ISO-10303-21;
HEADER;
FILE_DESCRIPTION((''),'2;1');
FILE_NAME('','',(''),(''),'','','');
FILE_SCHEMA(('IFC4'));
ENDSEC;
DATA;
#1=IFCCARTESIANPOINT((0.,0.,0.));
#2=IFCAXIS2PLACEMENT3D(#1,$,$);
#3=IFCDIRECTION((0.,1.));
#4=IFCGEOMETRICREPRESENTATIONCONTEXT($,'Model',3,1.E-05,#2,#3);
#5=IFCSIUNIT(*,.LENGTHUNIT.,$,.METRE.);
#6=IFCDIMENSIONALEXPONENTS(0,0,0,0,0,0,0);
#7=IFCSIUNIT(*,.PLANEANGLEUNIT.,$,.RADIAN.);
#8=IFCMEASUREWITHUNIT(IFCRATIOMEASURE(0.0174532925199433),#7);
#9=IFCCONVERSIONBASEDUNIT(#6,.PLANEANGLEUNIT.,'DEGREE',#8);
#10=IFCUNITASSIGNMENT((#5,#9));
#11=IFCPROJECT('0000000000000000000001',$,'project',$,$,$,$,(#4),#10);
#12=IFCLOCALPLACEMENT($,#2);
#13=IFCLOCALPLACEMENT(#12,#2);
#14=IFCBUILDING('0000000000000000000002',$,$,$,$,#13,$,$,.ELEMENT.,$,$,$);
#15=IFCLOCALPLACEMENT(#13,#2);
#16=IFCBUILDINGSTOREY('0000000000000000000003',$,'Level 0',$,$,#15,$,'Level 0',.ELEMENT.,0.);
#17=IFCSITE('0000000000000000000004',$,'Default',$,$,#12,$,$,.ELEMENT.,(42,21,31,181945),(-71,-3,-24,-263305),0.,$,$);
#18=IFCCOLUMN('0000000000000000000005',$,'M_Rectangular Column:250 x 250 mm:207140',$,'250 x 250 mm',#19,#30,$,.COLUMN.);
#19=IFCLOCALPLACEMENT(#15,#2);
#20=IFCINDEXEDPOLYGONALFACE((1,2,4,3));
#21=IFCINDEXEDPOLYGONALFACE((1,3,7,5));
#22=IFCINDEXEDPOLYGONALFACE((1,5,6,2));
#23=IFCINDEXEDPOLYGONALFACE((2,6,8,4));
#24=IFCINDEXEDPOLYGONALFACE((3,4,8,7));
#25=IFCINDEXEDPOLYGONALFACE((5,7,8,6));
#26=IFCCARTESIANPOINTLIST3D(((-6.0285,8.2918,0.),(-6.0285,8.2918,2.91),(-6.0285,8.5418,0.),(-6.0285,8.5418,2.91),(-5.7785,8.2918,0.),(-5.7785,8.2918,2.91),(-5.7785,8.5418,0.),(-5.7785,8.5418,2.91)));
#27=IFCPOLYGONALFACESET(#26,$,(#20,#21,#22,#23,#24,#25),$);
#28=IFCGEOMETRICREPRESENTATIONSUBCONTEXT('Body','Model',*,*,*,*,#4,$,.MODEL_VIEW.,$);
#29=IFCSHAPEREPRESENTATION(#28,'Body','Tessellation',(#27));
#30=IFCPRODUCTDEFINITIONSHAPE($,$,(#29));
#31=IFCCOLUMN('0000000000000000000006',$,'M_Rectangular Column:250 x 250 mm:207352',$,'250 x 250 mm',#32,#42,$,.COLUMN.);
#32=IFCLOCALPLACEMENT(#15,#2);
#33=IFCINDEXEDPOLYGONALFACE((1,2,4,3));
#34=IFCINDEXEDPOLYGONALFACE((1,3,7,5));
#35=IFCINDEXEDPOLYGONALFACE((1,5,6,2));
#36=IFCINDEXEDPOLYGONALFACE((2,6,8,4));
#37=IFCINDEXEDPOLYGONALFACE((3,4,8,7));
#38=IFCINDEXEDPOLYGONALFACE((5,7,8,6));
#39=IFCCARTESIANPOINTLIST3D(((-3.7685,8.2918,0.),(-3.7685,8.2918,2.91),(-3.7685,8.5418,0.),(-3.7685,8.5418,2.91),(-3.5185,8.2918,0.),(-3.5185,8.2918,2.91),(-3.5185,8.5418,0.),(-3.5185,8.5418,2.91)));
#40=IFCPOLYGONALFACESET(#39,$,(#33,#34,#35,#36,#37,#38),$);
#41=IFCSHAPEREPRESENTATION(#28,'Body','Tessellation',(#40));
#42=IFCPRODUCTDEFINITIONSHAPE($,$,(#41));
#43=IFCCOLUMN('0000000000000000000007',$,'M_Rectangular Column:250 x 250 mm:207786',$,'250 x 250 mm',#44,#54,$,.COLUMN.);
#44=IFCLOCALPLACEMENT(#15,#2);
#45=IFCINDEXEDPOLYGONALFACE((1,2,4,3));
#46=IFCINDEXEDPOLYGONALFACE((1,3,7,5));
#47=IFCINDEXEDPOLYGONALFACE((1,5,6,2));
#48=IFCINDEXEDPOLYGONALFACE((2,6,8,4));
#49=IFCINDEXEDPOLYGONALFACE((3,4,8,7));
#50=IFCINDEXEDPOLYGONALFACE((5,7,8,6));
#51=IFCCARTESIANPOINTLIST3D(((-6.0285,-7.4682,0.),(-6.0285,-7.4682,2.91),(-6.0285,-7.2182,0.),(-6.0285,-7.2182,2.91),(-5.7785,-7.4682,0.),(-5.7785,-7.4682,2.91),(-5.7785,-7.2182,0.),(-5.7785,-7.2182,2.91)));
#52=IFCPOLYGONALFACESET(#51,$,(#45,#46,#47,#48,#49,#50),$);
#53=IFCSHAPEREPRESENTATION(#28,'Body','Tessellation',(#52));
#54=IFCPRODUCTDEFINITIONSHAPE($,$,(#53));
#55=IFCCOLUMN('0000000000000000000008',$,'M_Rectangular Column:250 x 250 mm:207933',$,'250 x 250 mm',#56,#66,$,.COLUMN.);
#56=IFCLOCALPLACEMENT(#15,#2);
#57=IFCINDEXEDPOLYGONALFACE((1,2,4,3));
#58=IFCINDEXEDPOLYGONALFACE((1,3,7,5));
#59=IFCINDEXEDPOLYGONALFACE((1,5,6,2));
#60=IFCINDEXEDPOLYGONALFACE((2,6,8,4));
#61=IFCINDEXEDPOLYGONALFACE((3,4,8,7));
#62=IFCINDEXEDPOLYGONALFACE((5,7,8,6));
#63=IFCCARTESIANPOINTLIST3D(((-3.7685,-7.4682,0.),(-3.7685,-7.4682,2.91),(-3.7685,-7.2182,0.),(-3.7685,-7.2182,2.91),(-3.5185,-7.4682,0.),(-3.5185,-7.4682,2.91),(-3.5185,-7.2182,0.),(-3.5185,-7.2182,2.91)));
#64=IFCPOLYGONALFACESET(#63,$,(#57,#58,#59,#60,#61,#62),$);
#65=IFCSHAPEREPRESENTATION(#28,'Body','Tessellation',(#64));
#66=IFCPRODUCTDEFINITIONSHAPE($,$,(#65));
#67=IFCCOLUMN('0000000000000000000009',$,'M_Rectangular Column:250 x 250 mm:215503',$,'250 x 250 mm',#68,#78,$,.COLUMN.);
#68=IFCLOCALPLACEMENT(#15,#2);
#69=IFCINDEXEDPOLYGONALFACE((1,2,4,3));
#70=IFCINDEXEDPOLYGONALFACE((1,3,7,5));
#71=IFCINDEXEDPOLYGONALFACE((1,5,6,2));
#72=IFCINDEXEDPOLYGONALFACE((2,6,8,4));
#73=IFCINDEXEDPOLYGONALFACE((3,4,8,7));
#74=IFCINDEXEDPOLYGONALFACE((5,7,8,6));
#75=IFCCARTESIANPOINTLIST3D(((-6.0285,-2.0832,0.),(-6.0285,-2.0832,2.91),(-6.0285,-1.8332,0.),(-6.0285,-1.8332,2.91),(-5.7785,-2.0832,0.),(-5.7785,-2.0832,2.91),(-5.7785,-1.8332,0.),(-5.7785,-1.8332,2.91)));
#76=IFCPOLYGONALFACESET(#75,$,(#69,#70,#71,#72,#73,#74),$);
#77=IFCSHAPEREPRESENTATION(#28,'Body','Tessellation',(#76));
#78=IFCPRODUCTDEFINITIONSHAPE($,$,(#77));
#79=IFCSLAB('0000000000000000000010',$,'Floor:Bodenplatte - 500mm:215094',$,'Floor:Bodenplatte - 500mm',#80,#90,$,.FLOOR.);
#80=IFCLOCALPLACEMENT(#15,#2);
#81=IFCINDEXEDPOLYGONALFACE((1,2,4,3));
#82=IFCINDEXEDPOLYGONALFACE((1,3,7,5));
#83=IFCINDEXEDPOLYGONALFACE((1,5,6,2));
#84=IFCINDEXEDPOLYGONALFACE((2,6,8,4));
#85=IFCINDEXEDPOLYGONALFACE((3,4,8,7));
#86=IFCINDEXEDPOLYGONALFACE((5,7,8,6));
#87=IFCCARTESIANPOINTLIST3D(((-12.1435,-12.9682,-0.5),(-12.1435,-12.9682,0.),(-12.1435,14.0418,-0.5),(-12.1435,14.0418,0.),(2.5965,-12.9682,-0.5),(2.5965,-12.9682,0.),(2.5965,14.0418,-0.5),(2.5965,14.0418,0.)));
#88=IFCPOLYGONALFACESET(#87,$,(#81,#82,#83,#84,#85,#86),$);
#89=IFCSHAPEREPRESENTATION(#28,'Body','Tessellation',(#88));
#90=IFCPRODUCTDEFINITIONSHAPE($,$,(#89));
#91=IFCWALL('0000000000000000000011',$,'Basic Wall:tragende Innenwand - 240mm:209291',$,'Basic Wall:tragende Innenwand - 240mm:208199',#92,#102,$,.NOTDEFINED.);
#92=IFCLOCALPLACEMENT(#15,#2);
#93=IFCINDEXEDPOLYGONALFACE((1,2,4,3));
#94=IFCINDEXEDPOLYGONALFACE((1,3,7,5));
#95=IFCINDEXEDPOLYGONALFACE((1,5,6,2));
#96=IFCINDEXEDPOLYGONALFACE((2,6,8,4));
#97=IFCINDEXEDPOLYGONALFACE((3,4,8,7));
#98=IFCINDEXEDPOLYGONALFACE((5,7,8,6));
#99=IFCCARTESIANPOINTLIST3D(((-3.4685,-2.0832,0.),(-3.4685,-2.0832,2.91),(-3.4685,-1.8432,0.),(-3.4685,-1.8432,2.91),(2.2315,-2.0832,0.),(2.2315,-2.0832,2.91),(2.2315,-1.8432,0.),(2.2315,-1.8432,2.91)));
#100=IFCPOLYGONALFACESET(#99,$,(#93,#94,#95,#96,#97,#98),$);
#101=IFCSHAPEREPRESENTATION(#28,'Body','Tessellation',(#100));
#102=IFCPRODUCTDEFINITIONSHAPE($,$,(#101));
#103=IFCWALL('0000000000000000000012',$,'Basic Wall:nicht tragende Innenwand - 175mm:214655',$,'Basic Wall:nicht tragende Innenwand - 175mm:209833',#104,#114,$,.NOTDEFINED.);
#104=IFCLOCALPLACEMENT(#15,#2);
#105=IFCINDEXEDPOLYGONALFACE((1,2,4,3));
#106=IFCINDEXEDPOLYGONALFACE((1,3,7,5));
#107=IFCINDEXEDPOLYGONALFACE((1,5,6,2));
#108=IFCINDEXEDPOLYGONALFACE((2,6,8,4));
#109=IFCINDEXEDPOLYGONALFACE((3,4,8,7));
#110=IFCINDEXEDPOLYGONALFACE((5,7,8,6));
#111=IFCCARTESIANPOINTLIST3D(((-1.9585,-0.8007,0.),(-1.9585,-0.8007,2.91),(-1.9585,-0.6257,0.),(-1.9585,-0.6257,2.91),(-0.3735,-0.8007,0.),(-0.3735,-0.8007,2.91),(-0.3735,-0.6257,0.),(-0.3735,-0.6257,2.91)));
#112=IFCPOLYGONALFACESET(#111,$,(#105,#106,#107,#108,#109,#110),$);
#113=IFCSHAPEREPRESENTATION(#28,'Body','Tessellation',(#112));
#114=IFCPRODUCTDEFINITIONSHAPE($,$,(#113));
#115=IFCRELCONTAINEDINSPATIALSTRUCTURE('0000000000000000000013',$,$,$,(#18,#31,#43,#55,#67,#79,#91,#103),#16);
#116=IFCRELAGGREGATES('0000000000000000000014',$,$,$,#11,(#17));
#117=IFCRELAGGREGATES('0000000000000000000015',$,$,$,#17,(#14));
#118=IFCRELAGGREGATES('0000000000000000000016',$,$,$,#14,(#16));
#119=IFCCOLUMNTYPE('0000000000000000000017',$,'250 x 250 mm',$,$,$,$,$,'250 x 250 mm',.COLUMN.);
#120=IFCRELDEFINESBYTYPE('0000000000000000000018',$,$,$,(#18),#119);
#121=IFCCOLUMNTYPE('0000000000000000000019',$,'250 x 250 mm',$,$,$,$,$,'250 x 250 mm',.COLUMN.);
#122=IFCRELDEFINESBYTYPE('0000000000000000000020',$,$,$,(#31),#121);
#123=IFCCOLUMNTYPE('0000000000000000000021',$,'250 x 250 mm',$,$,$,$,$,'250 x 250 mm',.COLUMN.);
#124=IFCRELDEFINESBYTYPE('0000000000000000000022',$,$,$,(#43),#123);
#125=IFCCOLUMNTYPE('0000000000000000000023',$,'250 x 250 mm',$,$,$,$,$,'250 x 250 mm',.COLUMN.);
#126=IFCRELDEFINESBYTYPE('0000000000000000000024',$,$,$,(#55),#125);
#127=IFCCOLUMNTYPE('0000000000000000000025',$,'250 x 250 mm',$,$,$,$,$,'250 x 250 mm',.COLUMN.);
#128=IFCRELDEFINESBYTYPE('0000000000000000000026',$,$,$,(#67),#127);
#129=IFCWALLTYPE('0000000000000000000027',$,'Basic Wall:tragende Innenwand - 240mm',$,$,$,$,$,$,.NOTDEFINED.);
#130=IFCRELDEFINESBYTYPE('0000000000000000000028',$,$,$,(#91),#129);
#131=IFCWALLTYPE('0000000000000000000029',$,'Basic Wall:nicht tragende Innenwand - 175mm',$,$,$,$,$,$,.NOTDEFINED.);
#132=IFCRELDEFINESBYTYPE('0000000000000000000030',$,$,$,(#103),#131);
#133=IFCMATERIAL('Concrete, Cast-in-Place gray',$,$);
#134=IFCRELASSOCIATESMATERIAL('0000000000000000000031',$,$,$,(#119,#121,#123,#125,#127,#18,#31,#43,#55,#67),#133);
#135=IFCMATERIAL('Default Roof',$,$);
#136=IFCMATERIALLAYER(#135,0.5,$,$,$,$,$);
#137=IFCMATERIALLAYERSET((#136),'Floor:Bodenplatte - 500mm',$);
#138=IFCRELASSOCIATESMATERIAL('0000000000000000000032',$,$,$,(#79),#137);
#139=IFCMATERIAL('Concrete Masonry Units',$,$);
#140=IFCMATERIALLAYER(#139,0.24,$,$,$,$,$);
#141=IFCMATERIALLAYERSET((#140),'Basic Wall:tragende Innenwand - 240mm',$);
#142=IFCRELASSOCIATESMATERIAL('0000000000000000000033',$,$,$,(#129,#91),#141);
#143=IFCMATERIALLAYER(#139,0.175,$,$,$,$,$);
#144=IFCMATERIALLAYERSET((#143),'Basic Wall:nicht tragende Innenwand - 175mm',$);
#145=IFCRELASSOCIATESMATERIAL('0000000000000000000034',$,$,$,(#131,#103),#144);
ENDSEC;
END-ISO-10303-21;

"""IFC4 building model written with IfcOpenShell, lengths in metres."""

from ifc_helpers import new_model, entity, si_unit, converted_unit, direction, frame, frame_2d, origin, origin_2d_with_axis, place, context, subcontext, project, spatial, polyline, rectangle, extrude, clip, bounded_halfspace, source, transform, mapped, material, layer, layer_set, layer_usage, material_profile, profile_set, profile_usage, type_object, type_shapes, element, save


model = new_model("IFC4")

# Units and contexts
model_context = context("Model", 3, precision=1e-05, world=origin(), true_north=direction((0.0, 1.0)))
body_context = subcontext(model_context, "Body", "Model", "MODEL_VIEW")
ifc_project = project(units=[si_unit("LENGTHUNIT", "METRE"), converted_unit("PLANEANGLEUNIT", "DEGREE", entity("IfcRatioMeasure", 0.0174532925199433), si_unit("PLANEANGLEUNIT", "RADIAN"), dimensions=[0, 0, 0, 0, 0, 0, 0])], contexts=[model_context])

# Site, building, storey
site_placement = place(None, origin())
site = spatial("IfcSite", under=ifc_project, at=site_placement, Name="Default", CompositionType="ELEMENT", RefLatitude=(42, 21, 31, 181945), RefLongitude=(-71, -3, -24, -263305), RefElevation=0.0)
building_placement = place(site_placement, origin())
building = spatial("IfcBuilding", under=site, at=building_placement, CompositionType="ELEMENT")
storey_placement = place(building_placement, origin())
storey = spatial("IfcBuildingStorey", under=building, at=storey_placement, Name="Level 0", LongName="Level 0", CompositionType="ELEMENT", Elevation=0.0)

# Columns
ifc_material_1 = material(Name="Concrete, Cast-in-Place gray")
ifc_material_profile = material_profile(ifc_material_1, rectangle(XDim=0.25, YDim=0.25, at=frame_2d((0.0, 0.0), x_axis=(1.0, 0.0))))
ifc_profile_set = profile_set([ifc_material_profile], Name="250 x 250 mm")
ifc_profile_usage_1 = profile_usage(ifc_profile_set)
column_type_1 = type_object("IfcColumnType", Name="250 x 250 mm", ElementType="250 x 250 mm", PredefinedType="COLUMN", material=ifc_profile_set)
shared_shape_1 = source(origin(), body_context, "Body", "SweptSolid", [
    extrude(rectangle(XDim=0.25, YDim=0.25, at=frame_2d((0.0, 0.0), x_axis=(1.0, 0.0))), frame((-5.9035, 8.4168, 0.0), z_axis=(0.0, 0.0, 1.0), x_axis=(0.0, -1.0, 0.0)), (0.0, 0.0, 1.0), 2.91),
])
type_shapes(column_type_1, [shared_shape_1])
column_1_placement = place(storey_placement, origin())
element("IfcColumn", 1, at=column_1_placement, inside=storey, type_object=column_type_1, material=ifc_profile_usage_1, Name="M_Rectangular Column:250 x 250 mm:207140", ObjectType="250 x 250 mm", PredefinedType="COLUMN", context=body_context, shape_type="MappedRepresentation", body=[
    mapped(shared_shape_1, transform((0.0, 0.0, 0.0), scale=1.0)),
])
ifc_profile_usage_2 = profile_usage(ifc_profile_set)
column_type_2 = type_object("IfcColumnType", Name="250 x 250 mm", ElementType="250 x 250 mm", PredefinedType="COLUMN", material=ifc_profile_set)
shared_shape_2 = source(origin(), body_context, "Body", "SweptSolid", [
    extrude(rectangle(XDim=0.25, YDim=0.25, at=frame_2d((0.0, 0.0), x_axis=(1.0, 0.0))), frame((-3.6435, 8.4168, 0.0), z_axis=(0.0, 0.0, 1.0), x_axis=(0.0, -1.0, 0.0)), (0.0, 0.0, 1.0), 2.91),
])
type_shapes(column_type_2, [shared_shape_2])
column_2_placement = place(storey_placement, origin())
element("IfcColumn", 2, at=column_2_placement, inside=storey, type_object=column_type_2, material=ifc_profile_usage_2, Name="M_Rectangular Column:250 x 250 mm:207352", ObjectType="250 x 250 mm", PredefinedType="COLUMN", context=body_context, shape_type="MappedRepresentation", body=[
    mapped(shared_shape_2, transform((0.0, 0.0, 0.0), scale=1.0)),
])
ifc_profile_usage_3 = profile_usage(ifc_profile_set)
column_type_3 = type_object("IfcColumnType", Name="250 x 250 mm", ElementType="250 x 250 mm", PredefinedType="COLUMN", material=ifc_profile_set)
shared_shape_3 = source(origin(), body_context, "Body", "SweptSolid", [
    extrude(rectangle(XDim=0.25, YDim=0.25, at=frame_2d((0.0, 0.0), x_axis=(1.0, 0.0))), frame((-5.9035, -7.3432, 0.0), z_axis=(0.0, 0.0, 1.0), x_axis=(0.0, -1.0, 0.0)), (0.0, 0.0, 1.0), 2.91),
])
type_shapes(column_type_3, [shared_shape_3])
column_3_placement = place(storey_placement, origin())
element("IfcColumn", 3, at=column_3_placement, inside=storey, type_object=column_type_3, material=ifc_profile_usage_3, Name="M_Rectangular Column:250 x 250 mm:207786", ObjectType="250 x 250 mm", PredefinedType="COLUMN", context=body_context, shape_type="MappedRepresentation", body=[
    mapped(shared_shape_3, transform((0.0, 0.0, 0.0), scale=1.0)),
])
ifc_profile_usage_4 = profile_usage(ifc_profile_set)
column_type_4 = type_object("IfcColumnType", Name="250 x 250 mm", ElementType="250 x 250 mm", PredefinedType="COLUMN", material=ifc_profile_set)
shared_shape_4 = source(origin(), body_context, "Body", "SweptSolid", [
    extrude(rectangle(XDim=0.25, YDim=0.25, at=frame_2d((0.0, 0.0), x_axis=(1.0, 0.0))), frame((-3.6435, -7.3432, 0.0), z_axis=(0.0, 0.0, 1.0), x_axis=(0.0, -1.0, 0.0)), (0.0, 0.0, 1.0), 2.91),
])
type_shapes(column_type_4, [shared_shape_4])
column_4_placement = place(storey_placement, origin())
element("IfcColumn", 4, at=column_4_placement, inside=storey, type_object=column_type_4, material=ifc_profile_usage_4, Name="M_Rectangular Column:250 x 250 mm:207933", ObjectType="250 x 250 mm", PredefinedType="COLUMN", context=body_context, shape_type="MappedRepresentation", body=[
    mapped(shared_shape_4, transform((0.0, 0.0, 0.0), scale=1.0)),
])
ifc_profile_usage_5 = profile_usage(ifc_profile_set)
column_type_5 = type_object("IfcColumnType", Name="250 x 250 mm", ElementType="250 x 250 mm", PredefinedType="COLUMN", material=ifc_profile_set)
shared_shape_5 = source(origin(), body_context, "Body", "SweptSolid", [
    extrude(rectangle(XDim=0.25, YDim=0.25, at=frame_2d((0.0, 0.0), x_axis=(1.0, 0.0))), frame((-5.9035, -1.9582, 0.0), z_axis=(0.0, 0.0, 1.0), x_axis=(0.0, -1.0, 0.0)), (0.0, 0.0, 1.0), 2.91),
])
type_shapes(column_type_5, [shared_shape_5])
column_5_placement = place(storey_placement, origin())
element("IfcColumn", 5, at=column_5_placement, inside=storey, type_object=column_type_5, material=ifc_profile_usage_5, Name="M_Rectangular Column:250 x 250 mm:215503", ObjectType="250 x 250 mm", PredefinedType="COLUMN", context=body_context, shape_type="MappedRepresentation", body=[
    mapped(shared_shape_5, transform((0.0, 0.0, 0.0), scale=1.0)),
])

# Slab
ifc_material_2 = material(Name="Default Roof")
ifc_layer_1 = layer(ifc_material_2, 0.5)
ifc_layer_set_1 = layer_set([ifc_layer_1], Name="Floor:Bodenplatte - 500mm")
ifc_layer_usage_1 = layer_usage(ifc_layer_set_1, "AXIS3", "POSITIVE", 0.0)
slab_placement = place(storey_placement, origin())
element("IfcSlab", 6, at=slab_placement, inside=storey, material=ifc_layer_usage_1, Name="Floor:Bodenplatte - 500mm:215094", ObjectType="Floor:Bodenplatte - 500mm", PredefinedType="FLOOR", context=body_context, shape_type="SweptSolid", body=[
    extrude(rectangle(XDim=27.01, YDim=14.74, at=origin_2d_with_axis()), frame((-4.7735, 0.5368, 0.0), z_axis=(0.0, 0.0, -1.0), x_axis=(0.0, 1.0, 0.0)), (0.0, 0.0, 1.0), 0.5),
])

# Walls
ifc_material_3 = material(Name="Concrete Masonry Units")
ifc_layer_2 = layer(ifc_material_3, 0.24)
ifc_layer_set_2 = layer_set([ifc_layer_2], Name="Basic Wall:tragende Innenwand - 240mm")
ifc_layer_usage_2 = layer_usage(ifc_layer_set_2, "AXIS2", "NEGATIVE", 0.12)
wall_type_1 = type_object("IfcWallType", Name="Basic Wall:tragende Innenwand - 240mm", PredefinedType="NOTDEFINED", material=ifc_layer_set_2)
wall_1_placement = place(storey_placement, frame((-3.4685, -1.9632, 0.0)))
element("IfcWall", 7, at=wall_1_placement, inside=storey, type_object=wall_type_1, material=ifc_layer_usage_2, Name="Basic Wall:tragende Innenwand - 240mm:209291", ObjectType="Basic Wall:tragende Innenwand - 240mm:208199", PredefinedType="NOTDEFINED", context=body_context, shape_type="Clipping", body=[
    clip(extrude(rectangle(XDim=5.7, YDim=0.24, at=frame_2d((2.85, 0.0), x_axis=(-1.0, 0.0))), origin(), (0.0, 0.0, 1.0), 2.91), bounded_halfspace(frame((0.0, -0.12, 2.91), z_axis=(0.0, 0.0, -1.0), x_axis=(0.0, -1.0, 0.0)), True, frame((0.0, -0.12, 2.91)), polyline([(0.0, 0.0), (5.7, 0.0), (5.7, 0.24), (3.27, 0.24), (3.095, 0.24), (1.51, 0.24), (1.335, 0.24), (0.0, 0.24), (0.0, 0.0)]))),
])
ifc_layer_3 = layer(ifc_material_3, 0.175)
ifc_layer_set_3 = layer_set([ifc_layer_3], Name="Basic Wall:nicht tragende Innenwand - 175mm")
ifc_layer_usage_3 = layer_usage(ifc_layer_set_3, "AXIS2", "NEGATIVE", 0.0875)
wall_type_2 = type_object("IfcWallType", Name="Basic Wall:nicht tragende Innenwand - 175mm", PredefinedType="NOTDEFINED", material=ifc_layer_set_3)
wall_2_placement = place(storey_placement, frame((-1.9585, -0.7132, 0.0)))
element("IfcWall", 8, at=wall_2_placement, inside=storey, type_object=wall_type_2, material=ifc_layer_usage_3, Name="Basic Wall:nicht tragende Innenwand - 175mm:214655", ObjectType="Basic Wall:nicht tragende Innenwand - 175mm:209833", PredefinedType="NOTDEFINED", context=body_context, shape_type="Clipping", body=[
    clip(extrude(rectangle(XDim=1.585, YDim=0.175, at=frame_2d((0.7925, 0.0), x_axis=(-1.0, 0.0))), origin(), (0.0, 0.0, 1.0), 2.91), bounded_halfspace(frame((0.0, -0.0875, 2.91), z_axis=(0.0, 0.0, -1.0), x_axis=(0.0, -1.0, 0.0)), True, frame((0.0, -0.0875, 2.91)), polyline([(0.0, 0.0), (1.585, 0.0), (1.585, 0.175), (0.0, 0.175), (0.0, 0.0)]))),
])

save(model, "model.ifc")
